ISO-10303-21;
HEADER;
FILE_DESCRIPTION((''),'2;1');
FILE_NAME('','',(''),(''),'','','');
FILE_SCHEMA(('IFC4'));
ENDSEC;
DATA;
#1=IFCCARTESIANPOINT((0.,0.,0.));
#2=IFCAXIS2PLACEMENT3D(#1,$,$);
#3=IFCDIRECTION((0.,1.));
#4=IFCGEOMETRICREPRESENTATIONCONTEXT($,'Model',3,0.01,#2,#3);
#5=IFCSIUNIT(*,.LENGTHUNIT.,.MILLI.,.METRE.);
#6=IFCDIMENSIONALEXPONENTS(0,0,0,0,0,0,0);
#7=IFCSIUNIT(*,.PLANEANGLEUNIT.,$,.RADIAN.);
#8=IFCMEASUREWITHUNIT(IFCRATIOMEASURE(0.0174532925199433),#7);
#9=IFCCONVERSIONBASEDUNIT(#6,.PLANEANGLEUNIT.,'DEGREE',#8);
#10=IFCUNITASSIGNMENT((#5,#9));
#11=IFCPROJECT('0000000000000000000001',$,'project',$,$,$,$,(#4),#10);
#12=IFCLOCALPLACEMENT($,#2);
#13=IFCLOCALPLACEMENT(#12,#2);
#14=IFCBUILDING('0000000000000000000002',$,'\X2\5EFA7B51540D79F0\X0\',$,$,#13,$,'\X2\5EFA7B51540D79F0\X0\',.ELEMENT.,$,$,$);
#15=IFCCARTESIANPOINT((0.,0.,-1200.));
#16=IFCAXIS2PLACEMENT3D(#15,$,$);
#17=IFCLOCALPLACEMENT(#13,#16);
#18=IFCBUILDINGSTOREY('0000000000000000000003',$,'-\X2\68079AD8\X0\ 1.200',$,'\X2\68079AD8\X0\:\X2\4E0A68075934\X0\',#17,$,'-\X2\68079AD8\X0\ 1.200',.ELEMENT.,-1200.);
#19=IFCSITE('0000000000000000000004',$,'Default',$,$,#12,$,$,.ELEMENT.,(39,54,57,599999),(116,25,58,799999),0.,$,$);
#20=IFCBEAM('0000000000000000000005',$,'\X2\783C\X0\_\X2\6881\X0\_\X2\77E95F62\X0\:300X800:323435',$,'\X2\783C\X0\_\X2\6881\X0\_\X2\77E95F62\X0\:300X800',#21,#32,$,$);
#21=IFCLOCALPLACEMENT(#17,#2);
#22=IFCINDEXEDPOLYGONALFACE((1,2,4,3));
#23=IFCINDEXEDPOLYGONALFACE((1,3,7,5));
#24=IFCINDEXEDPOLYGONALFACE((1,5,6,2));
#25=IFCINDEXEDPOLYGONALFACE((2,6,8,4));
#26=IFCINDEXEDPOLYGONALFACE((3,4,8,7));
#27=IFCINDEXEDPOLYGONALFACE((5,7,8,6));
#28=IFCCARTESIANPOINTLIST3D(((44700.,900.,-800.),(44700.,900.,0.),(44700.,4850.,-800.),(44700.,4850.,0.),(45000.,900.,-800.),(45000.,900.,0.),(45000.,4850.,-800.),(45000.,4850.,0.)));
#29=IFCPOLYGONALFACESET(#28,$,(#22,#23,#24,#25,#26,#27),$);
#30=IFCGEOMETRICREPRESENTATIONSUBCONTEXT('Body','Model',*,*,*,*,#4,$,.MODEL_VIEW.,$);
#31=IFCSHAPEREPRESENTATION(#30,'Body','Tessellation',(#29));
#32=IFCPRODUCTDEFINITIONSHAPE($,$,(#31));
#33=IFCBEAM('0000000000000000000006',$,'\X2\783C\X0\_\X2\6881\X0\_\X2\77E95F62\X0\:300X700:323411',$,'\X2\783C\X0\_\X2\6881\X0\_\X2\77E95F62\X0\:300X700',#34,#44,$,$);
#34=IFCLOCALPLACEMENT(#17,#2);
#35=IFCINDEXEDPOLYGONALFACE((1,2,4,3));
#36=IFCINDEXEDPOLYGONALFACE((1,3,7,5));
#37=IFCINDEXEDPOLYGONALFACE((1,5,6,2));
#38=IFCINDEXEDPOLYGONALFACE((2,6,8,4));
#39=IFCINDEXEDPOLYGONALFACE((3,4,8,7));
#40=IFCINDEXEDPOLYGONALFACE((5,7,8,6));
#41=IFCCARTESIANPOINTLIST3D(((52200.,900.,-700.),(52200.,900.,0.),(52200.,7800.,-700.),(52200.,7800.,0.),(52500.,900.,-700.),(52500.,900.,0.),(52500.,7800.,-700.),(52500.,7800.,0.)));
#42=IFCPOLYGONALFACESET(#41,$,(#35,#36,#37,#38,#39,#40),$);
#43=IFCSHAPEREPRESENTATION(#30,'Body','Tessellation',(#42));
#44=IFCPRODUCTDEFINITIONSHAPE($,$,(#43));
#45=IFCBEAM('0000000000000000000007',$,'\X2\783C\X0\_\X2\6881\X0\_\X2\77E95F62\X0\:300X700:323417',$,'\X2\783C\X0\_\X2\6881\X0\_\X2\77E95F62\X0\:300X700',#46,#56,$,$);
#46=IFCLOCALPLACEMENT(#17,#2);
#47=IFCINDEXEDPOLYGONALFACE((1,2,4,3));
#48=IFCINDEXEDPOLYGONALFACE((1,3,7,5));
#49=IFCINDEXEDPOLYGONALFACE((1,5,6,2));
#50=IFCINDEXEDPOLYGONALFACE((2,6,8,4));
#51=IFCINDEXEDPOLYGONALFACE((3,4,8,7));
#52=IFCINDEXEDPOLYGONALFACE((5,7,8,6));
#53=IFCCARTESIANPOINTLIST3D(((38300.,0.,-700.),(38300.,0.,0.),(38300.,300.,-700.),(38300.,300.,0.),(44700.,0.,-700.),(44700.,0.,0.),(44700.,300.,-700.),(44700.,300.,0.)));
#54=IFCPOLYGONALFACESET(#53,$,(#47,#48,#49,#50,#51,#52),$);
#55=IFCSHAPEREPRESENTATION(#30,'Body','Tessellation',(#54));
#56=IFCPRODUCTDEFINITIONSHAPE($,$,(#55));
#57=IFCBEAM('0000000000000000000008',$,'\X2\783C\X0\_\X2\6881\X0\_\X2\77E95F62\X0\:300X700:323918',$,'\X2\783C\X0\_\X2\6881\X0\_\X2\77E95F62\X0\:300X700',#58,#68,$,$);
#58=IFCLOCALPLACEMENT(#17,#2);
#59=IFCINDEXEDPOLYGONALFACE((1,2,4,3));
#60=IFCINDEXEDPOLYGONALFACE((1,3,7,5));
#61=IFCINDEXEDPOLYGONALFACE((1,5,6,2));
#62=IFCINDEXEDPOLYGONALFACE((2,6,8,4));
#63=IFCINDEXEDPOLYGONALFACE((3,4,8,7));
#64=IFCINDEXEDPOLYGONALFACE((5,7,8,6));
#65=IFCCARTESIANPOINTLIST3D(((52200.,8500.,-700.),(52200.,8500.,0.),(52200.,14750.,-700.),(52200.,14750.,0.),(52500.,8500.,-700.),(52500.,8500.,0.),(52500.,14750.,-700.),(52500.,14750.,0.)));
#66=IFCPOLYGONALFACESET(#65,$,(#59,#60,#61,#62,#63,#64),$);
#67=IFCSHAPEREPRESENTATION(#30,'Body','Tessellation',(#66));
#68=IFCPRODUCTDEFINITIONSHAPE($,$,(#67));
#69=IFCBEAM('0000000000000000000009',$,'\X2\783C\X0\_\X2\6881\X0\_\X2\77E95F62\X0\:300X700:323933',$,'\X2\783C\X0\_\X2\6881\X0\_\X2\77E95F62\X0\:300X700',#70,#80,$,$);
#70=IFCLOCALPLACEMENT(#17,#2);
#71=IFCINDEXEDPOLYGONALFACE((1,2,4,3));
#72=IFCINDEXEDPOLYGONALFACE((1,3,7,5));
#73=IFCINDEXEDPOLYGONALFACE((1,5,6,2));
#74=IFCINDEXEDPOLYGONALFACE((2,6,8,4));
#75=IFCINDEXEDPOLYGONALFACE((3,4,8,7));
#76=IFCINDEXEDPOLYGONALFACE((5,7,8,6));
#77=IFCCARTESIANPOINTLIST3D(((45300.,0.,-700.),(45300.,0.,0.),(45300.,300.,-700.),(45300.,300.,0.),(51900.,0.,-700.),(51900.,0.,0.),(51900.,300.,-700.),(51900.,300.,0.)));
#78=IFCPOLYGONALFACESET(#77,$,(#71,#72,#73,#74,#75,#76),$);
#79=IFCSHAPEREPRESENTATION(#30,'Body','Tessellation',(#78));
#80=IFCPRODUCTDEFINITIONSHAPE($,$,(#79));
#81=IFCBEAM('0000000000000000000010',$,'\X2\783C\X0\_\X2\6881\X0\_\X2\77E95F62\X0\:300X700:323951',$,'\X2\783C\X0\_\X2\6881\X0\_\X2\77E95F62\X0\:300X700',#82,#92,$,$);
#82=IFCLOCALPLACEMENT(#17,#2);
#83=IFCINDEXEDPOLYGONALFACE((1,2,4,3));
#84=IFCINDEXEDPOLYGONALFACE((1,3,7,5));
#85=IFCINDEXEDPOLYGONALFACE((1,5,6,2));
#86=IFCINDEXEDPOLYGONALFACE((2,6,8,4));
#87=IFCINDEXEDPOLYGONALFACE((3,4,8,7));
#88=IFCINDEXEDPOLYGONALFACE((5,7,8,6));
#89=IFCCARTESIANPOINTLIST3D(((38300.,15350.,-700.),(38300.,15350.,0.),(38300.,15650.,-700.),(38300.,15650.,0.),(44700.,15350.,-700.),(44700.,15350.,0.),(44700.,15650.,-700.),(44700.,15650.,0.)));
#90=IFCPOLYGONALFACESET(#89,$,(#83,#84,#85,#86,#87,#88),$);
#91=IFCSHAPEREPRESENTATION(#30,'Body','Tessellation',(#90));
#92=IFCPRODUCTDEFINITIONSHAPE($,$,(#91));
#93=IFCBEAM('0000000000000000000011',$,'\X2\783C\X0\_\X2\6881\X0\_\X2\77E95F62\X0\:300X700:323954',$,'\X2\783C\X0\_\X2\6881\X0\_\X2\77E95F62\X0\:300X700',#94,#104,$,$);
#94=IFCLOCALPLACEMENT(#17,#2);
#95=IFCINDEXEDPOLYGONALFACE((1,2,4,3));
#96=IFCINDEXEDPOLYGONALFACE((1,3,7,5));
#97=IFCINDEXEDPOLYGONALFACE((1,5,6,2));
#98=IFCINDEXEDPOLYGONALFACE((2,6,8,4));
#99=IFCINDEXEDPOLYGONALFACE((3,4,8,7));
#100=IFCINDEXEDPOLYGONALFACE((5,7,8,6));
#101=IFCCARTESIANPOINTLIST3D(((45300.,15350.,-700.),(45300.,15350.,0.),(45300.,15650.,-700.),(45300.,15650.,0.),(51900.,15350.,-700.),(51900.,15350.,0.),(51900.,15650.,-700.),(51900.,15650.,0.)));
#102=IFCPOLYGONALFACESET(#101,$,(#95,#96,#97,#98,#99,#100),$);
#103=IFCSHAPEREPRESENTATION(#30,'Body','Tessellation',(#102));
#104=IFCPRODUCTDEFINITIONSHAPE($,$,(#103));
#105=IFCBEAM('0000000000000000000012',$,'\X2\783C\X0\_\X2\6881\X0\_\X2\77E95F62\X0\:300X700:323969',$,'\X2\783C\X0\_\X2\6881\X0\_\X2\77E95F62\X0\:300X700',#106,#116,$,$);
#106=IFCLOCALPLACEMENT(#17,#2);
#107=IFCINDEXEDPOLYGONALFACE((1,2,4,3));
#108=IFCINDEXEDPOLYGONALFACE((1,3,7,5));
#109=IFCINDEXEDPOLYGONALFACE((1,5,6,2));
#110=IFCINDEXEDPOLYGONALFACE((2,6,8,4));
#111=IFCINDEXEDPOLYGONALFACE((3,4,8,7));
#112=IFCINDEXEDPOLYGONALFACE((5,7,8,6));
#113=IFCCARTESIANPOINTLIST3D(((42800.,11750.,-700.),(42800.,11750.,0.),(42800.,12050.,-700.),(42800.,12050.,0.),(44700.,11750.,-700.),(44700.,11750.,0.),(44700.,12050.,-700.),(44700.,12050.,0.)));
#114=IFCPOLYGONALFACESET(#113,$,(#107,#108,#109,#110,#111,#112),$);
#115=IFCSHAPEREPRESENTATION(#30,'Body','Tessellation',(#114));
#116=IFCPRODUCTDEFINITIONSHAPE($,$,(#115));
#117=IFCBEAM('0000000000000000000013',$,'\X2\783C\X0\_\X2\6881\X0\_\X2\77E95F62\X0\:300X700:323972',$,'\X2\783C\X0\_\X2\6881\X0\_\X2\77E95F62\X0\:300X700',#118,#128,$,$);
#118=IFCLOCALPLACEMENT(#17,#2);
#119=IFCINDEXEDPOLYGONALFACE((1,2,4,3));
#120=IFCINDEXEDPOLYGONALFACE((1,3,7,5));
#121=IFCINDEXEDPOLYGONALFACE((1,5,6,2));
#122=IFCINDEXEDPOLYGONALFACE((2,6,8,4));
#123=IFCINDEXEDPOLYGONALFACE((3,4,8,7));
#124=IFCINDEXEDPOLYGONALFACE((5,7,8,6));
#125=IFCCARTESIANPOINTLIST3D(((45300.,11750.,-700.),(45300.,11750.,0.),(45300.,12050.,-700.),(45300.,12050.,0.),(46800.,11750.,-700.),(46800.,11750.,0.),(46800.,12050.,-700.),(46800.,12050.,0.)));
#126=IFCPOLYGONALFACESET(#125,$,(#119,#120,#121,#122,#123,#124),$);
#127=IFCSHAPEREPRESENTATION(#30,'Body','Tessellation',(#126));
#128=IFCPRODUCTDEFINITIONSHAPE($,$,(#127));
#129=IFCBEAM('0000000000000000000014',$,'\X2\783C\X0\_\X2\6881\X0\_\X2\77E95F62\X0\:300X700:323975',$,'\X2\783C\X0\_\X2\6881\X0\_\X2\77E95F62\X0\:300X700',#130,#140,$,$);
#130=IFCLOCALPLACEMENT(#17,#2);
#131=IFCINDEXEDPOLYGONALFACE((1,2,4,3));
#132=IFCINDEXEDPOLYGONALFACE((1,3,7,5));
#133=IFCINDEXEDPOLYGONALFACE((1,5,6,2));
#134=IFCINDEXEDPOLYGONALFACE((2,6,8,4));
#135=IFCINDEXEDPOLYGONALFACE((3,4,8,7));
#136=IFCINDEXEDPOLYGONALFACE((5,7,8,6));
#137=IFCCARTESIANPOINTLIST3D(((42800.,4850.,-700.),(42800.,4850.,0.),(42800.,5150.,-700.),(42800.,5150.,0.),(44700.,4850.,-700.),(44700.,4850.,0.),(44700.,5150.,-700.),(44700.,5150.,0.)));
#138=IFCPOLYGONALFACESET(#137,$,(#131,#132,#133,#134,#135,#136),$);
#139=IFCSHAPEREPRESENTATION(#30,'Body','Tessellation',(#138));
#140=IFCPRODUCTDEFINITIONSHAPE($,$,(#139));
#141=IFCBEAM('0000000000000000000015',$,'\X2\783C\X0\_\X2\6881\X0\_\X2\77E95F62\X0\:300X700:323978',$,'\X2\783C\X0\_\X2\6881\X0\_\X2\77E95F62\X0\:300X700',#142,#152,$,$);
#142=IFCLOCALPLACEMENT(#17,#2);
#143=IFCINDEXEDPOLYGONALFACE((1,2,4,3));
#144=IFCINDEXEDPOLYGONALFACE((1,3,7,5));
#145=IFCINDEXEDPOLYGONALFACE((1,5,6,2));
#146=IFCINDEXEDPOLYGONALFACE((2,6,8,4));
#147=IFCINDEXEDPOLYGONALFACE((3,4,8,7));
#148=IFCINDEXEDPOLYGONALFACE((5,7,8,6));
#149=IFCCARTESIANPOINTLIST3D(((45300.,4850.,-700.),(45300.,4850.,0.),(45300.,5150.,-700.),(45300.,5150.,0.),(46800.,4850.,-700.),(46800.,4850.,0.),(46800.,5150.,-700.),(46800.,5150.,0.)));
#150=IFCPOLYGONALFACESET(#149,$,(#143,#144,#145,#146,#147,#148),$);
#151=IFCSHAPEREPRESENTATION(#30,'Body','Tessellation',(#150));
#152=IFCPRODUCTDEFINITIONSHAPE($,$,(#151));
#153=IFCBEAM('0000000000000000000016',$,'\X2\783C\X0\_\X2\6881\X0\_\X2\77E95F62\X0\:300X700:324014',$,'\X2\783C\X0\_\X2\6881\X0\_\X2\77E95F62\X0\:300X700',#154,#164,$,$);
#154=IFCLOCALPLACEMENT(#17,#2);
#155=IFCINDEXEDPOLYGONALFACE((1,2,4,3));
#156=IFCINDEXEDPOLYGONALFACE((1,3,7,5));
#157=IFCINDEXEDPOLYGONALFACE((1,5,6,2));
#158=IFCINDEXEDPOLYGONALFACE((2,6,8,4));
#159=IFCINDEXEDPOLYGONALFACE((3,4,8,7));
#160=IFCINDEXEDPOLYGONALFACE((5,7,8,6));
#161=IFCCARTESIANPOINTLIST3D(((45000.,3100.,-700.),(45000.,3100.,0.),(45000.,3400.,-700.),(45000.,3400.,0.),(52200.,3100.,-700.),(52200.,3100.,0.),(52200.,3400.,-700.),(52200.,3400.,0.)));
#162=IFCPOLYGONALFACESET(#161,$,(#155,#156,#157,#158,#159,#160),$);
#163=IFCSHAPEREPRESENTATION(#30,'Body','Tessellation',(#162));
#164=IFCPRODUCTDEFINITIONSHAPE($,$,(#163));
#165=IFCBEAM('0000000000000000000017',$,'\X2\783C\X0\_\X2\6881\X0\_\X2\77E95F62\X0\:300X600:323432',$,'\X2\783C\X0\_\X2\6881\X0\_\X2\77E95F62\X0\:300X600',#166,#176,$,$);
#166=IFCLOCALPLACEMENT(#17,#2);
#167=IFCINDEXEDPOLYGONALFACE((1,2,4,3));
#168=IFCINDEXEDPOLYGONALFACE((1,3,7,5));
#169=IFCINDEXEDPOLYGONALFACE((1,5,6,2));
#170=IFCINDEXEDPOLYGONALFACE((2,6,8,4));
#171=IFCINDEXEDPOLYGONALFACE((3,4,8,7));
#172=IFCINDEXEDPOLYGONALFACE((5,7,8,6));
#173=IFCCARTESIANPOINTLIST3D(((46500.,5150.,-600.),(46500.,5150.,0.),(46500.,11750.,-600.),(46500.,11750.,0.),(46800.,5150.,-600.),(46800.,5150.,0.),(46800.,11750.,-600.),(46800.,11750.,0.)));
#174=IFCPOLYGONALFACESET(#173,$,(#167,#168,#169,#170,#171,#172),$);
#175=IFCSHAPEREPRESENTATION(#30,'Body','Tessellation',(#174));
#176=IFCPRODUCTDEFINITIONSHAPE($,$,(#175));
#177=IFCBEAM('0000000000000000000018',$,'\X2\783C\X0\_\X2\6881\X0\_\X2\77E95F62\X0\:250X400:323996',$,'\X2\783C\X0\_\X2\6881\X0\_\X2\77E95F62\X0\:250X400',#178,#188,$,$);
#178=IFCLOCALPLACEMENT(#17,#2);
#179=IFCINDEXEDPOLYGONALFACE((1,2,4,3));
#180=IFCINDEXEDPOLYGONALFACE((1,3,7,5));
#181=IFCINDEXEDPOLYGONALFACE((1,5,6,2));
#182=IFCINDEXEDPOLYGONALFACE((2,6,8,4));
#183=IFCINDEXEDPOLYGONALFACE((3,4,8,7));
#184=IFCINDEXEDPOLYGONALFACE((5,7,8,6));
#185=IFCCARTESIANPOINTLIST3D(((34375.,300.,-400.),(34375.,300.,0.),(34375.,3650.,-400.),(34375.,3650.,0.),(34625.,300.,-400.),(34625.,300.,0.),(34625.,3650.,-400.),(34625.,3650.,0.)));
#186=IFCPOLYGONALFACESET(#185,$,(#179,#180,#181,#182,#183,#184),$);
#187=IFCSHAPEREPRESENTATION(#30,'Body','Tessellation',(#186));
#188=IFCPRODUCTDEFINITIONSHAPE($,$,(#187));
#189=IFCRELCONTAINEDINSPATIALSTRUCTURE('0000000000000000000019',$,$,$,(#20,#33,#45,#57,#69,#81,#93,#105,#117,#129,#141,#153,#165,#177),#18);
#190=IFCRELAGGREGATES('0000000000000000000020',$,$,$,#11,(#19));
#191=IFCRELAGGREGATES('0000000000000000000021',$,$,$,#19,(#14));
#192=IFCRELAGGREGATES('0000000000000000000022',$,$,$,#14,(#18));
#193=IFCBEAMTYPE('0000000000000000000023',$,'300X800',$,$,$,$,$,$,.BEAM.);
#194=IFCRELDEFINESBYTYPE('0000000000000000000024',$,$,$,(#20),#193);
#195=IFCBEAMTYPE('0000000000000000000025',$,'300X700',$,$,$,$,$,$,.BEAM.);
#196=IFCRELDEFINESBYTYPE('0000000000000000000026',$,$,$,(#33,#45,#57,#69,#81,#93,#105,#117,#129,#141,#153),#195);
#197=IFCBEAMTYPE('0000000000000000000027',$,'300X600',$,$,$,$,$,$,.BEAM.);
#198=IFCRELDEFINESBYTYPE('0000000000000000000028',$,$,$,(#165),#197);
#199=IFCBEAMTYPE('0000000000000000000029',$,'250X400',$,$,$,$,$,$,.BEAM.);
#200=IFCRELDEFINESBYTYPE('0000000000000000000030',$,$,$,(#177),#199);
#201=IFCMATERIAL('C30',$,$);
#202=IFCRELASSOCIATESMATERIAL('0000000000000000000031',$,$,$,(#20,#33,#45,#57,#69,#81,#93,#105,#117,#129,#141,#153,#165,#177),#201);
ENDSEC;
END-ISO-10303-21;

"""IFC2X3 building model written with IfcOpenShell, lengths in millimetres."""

from ifc_helpers import new_model, entity, si_unit, converted_unit, direction, frame, frame_2d, origin, place, context, subcontext, project, spatial, rectangle, extrude, material, type_object, element, save


model = new_model("IFC2X3")

# Units and contexts
model_context = context("Model", 3, precision=0.01, world=origin(), true_north=direction((0.0, 1.0)))
body_context = subcontext(model_context, "Body", "Model", "MODEL_VIEW")
ifc_project = project(units=[si_unit("LENGTHUNIT", "METRE", prefix="MILLI"), converted_unit("PLANEANGLEUNIT", "DEGREE", entity("IfcRatioMeasure", 0.0174532925199433), si_unit("PLANEANGLEUNIT", "RADIAN"), dimensions=[0, 0, 0, 0, 0, 0, 0])], contexts=[model_context])

# Site, building, storey
site_placement = place(None, origin())
site = spatial("IfcSite", under=ifc_project, at=site_placement, Name="Default", CompositionType="ELEMENT", RefLatitude=(39, 54, 57, 599999), RefLongitude=(116, 25, 58, 799999), RefElevation=0.0)
building_placement = place(site_placement, origin())
building = spatial("IfcBuilding", under=site, at=building_placement, Name="建筑名称", LongName="建筑名称", CompositionType="ELEMENT")
storey_placement = place(building_placement, frame((0.0, 0.0, -1200.0)))
storey = spatial("IfcBuildingStorey", under=building, at=storey_placement, Name="-标高 1.200", ObjectType="标高:上标头", LongName="-标高 1.200", CompositionType="ELEMENT", Elevation=-1200.0)

# Beams
ifc_material_1 = material(Name="C30")
beam_type_1 = type_object("IfcBeamType", Name="300X800", PredefinedType="BEAM")
beam_1_placement = place(storey_placement, frame((45000.0, 150.0, 0.0), z_axis=(0.0, 0.0, 1.0), x_axis=(0.0, 1.0, 0.0)))
element("IfcBeam", 1, at=beam_1_placement, inside=storey, type_object=beam_type_1, material=ifc_material_1, Name="砼_梁_矩形:300X800:323435", ObjectType="砼_梁_矩形:300X800", context=body_context, shape_type="SweptSolid", body=[
    extrude(rectangle(XDim=800.0, YDim=300.0, at=frame_2d((0.0, 0.0), x_axis=(1.0, 0.0))), frame((750.0, 150.0, -400.0), z_axis=(1.0, 0.0, 0.0), x_axis=(0.0, 0.0, -1.0)), (0.0, 0.0, 1.0), 3950.0),
])
beam_type_2 = type_object("IfcBeamType", Name="300X700", PredefinedType="BEAM")
beam_2_placement = place(storey_placement, frame((52500.0, 0.0, 0.0), z_axis=(0.0, 0.0, 1.0), x_axis=(0.0, 1.0, 0.0)))
element("IfcBeam", 2, at=beam_2_placement, inside=storey, type_object=beam_type_2, material=ifc_material_1, Name="砼_梁_矩形:300X700:323411", ObjectType="砼_梁_矩形:300X700", context=body_context, shape_type="SweptSolid", body=[
    extrude(rectangle(XDim=700.0, YDim=300.0, at=frame_2d((0.0, 0.0), x_axis=(1.0, 0.0))), frame((900.0, 150.0, -350.0), z_axis=(1.0, 0.0, 0.0), x_axis=(0.0, 0.0, -1.0)), (0.0, 0.0, 1.0), 6900.0),
])
beam_3_placement = place(storey_placement, frame((38000.0, 0.0, 0.0)))
element("IfcBeam", 3, at=beam_3_placement, inside=storey, type_object=beam_type_2, material=ifc_material_1, Name="砼_梁_矩形:300X700:323417", ObjectType="砼_梁_矩形:300X700", context=body_context, shape_type="SweptSolid", body=[
    extrude(rectangle(XDim=700.0, YDim=300.0, at=frame_2d((0.0, 0.0), x_axis=(1.0, 0.0))), frame((300.0, 150.0, -350.0), z_axis=(1.0, 0.0, 0.0), x_axis=(0.0, 0.0, -1.0)), (0.0, 0.0, 1.0), 6400.0),
])
beam_4_placement = place(storey_placement, frame((52500.0, 8150.0, 0.0), z_axis=(0.0, 0.0, 1.0), x_axis=(0.0, 1.0, 0.0)))
element("IfcBeam", 4, at=beam_4_placement, inside=storey, type_object=beam_type_2, material=ifc_material_1, Name="砼_梁_矩形:300X700:323918", ObjectType="砼_梁_矩形:300X700", context=body_context, shape_type="SweptSolid", body=[
    extrude(rectangle(XDim=700.0, YDim=300.0, at=frame_2d((0.0, 0.0), x_axis=(1.0, 0.0))), frame((350.0, 150.0, -350.0), z_axis=(1.0, 0.0, 0.0), x_axis=(0.0, 0.0, -1.0)), (0.0, 0.0, 1.0), 6250.0),
])
beam_5_placement = place(storey_placement, frame((45000.0, 0.0, 0.0)))
element("IfcBeam", 5, at=beam_5_placement, inside=storey, type_object=beam_type_2, material=ifc_material_1, Name="砼_梁_矩形:300X700:323933", ObjectType="砼_梁_矩形:300X700", context=body_context, shape_type="SweptSolid", body=[
    extrude(rectangle(XDim=700.0, YDim=300.0, at=frame_2d((0.0, 0.0), x_axis=(1.0, 0.0))), frame((300.0, 150.0, -350.0), z_axis=(1.0, 0.0, 0.0), x_axis=(0.0, 0.0, -1.0)), (0.0, 0.0, 1.0), 6600.0),
])
beam_6_placement = place(storey_placement, frame((38000.0, 15650.0, 0.0)))
element("IfcBeam", 6, at=beam_6_placement, inside=storey, type_object=beam_type_2, material=ifc_material_1, Name="砼_梁_矩形:300X700:323951", ObjectType="砼_梁_矩形:300X700", context=body_context, shape_type="SweptSolid", body=[
    extrude(rectangle(XDim=700.0, YDim=300.0, at=frame_2d((0.0, 0.0), x_axis=(1.0, 0.0))), frame((300.0, -150.0, -350.0), z_axis=(1.0, 0.0, 0.0), x_axis=(0.0, 0.0, -1.0)), (0.0, 0.0, 1.0), 6400.0),
])
beam_7_placement = place(storey_placement, frame((45000.0, 15650.0, 0.0)))
element("IfcBeam", 7, at=beam_7_placement, inside=storey, type_object=beam_type_2, material=ifc_material_1, Name="砼_梁_矩形:300X700:323954", ObjectType="砼_梁_矩形:300X700", context=body_context, shape_type="SweptSolid", body=[
    extrude(rectangle(XDim=700.0, YDim=300.0, at=frame_2d((0.0, 0.0), x_axis=(1.0, 0.0))), frame((300.0, -150.0, -350.0), z_axis=(1.0, 0.0, 0.0), x_axis=(0.0, 0.0, -1.0)), (0.0, 0.0, 1.0), 6600.0),
])
beam_8_placement = place(storey_placement, frame((42800.0, 12050.0, 0.0)))
element("IfcBeam", 8, at=beam_8_placement, inside=storey, type_object=beam_type_2, material=ifc_material_1, Name="砼_梁_矩形:300X700:323969", ObjectType="砼_梁_矩形:300X700", context=body_context, shape_type="SweptSolid", body=[
    extrude(rectangle(XDim=700.0, YDim=300.0, at=frame_2d((0.0, 0.0), x_axis=(1.0, 0.0))), frame((0.0, -150.0, -350.0), z_axis=(1.0, 0.0, 0.0), x_axis=(0.0, 0.0, -1.0)), (0.0, 0.0, 1.0), 1900.0),
])
beam_9_placement = place(storey_placement, frame((45000.0, 12050.0, 0.0)))
element("IfcBeam", 9, at=beam_9_placement, inside=storey, type_object=beam_type_2, material=ifc_material_1, Name="砼_梁_矩形:300X700:323972", ObjectType="砼_梁_矩形:300X700", context=body_context, shape_type="SweptSolid", body=[
    extrude(rectangle(XDim=700.0, YDim=300.0, at=frame_2d((0.0, 0.0), x_axis=(1.0, 0.0))), frame((300.0, -150.0, -350.0), z_axis=(1.0, 0.0, 0.0), x_axis=(0.0, 0.0, -1.0)), (0.0, 0.0, 1.0), 1500.0),
])
beam_10_placement = place(storey_placement, frame((42800.0, 4850.0, 0.0)))
element("IfcBeam", 10, at=beam_10_placement, inside=storey, type_object=beam_type_2, material=ifc_material_1, Name="砼_梁_矩形:300X700:323975", ObjectType="砼_梁_矩形:300X700", context=body_context, shape_type="SweptSolid", body=[
    extrude(rectangle(XDim=700.0, YDim=300.0, at=frame_2d((0.0, 0.0), x_axis=(1.0, 0.0))), frame((0.0, 150.0, -350.0), z_axis=(1.0, 0.0, 0.0), x_axis=(0.0, 0.0, -1.0)), (0.0, 0.0, 1.0), 1900.0),
])
beam_11_placement = place(storey_placement, frame((44850.0, 4850.0, 0.0)))
element("IfcBeam", 11, at=beam_11_placement, inside=storey, type_object=beam_type_2, material=ifc_material_1, Name="砼_梁_矩形:300X700:323978", ObjectType="砼_梁_矩形:300X700", context=body_context, shape_type="SweptSolid", body=[
    extrude(rectangle(XDim=700.0, YDim=300.0, at=frame_2d((0.0, 0.0), x_axis=(1.0, 0.0))), frame((450.0, 150.0, -350.0), z_axis=(1.0, 0.0, 0.0), x_axis=(0.0, 0.0, -1.0)), (0.0, 0.0, 1.0), 1500.0),
])
beam_12_placement = place(storey_placement, frame((45000.0, 3250.0, 0.0)))
element("IfcBeam", 12, at=beam_12_placement, inside=storey, type_object=beam_type_2, material=ifc_material_1, Name="砼_梁_矩形:300X700:324014", ObjectType="砼_梁_矩形:300X700", context=body_context, shape_type="SweptSolid", body=[
    extrude(rectangle(XDim=700.0, YDim=300.0, at=frame_2d((0.0, 0.0), x_axis=(1.0, 0.0))), frame((0.0, 0.0, -350.0), z_axis=(1.0, 0.0, 0.0), x_axis=(0.0, 0.0, -1.0)), (0.0, 0.0, 1.0), 7200.0),
])
beam_type_3 = type_object("IfcBeamType", Name="300X600", PredefinedType="BEAM")
beam_13_placement = place(storey_placement, frame((46800.0, 4850.0, 0.0), z_axis=(0.0, 0.0, 1.0), x_axis=(0.0, 1.0, 0.0)))
element("IfcBeam", 13, at=beam_13_placement, inside=storey, type_object=beam_type_3, material=ifc_material_1, Name="砼_梁_矩形:300X600:323432", ObjectType="砼_梁_矩形:300X600", context=body_context, shape_type="SweptSolid", body=[
    extrude(rectangle(XDim=600.0, YDim=300.0, at=frame_2d((0.0, 0.0), x_axis=(1.0, 0.0))), frame((300.0, 150.0, -300.0), z_axis=(1.0, 0.0, 0.0), x_axis=(0.0, 0.0, -1.0)), (0.0, 0.0, 1.0), 6600.0),
])
beam_type_4 = type_object("IfcBeamType", Name="250X400", PredefinedType="BEAM")
beam_14_placement = place(storey_placement, frame((34500.0, 0.0, 0.0), z_axis=(0.0, 0.0, 1.0), x_axis=(0.0, 1.0, 0.0)))
element("IfcBeam", 14, at=beam_14_placement, inside=storey, type_object=beam_type_4, material=ifc_material_1, Name="砼_梁_矩形:250X400:323996", ObjectType="砼_梁_矩形:250X400", context=body_context, shape_type="SweptSolid", body=[
    extrude(rectangle(XDim=400.0, YDim=250.0, at=frame_2d((0.0, 0.0), x_axis=(1.0, 0.0))), frame((300.0, 0.0, -200.0), z_axis=(1.0, 0.0, 0.0), x_axis=(0.0, 0.0, -1.0)), (0.0, 0.0, 1.0), 3350.0),
])

save(model, "model.ifc")
